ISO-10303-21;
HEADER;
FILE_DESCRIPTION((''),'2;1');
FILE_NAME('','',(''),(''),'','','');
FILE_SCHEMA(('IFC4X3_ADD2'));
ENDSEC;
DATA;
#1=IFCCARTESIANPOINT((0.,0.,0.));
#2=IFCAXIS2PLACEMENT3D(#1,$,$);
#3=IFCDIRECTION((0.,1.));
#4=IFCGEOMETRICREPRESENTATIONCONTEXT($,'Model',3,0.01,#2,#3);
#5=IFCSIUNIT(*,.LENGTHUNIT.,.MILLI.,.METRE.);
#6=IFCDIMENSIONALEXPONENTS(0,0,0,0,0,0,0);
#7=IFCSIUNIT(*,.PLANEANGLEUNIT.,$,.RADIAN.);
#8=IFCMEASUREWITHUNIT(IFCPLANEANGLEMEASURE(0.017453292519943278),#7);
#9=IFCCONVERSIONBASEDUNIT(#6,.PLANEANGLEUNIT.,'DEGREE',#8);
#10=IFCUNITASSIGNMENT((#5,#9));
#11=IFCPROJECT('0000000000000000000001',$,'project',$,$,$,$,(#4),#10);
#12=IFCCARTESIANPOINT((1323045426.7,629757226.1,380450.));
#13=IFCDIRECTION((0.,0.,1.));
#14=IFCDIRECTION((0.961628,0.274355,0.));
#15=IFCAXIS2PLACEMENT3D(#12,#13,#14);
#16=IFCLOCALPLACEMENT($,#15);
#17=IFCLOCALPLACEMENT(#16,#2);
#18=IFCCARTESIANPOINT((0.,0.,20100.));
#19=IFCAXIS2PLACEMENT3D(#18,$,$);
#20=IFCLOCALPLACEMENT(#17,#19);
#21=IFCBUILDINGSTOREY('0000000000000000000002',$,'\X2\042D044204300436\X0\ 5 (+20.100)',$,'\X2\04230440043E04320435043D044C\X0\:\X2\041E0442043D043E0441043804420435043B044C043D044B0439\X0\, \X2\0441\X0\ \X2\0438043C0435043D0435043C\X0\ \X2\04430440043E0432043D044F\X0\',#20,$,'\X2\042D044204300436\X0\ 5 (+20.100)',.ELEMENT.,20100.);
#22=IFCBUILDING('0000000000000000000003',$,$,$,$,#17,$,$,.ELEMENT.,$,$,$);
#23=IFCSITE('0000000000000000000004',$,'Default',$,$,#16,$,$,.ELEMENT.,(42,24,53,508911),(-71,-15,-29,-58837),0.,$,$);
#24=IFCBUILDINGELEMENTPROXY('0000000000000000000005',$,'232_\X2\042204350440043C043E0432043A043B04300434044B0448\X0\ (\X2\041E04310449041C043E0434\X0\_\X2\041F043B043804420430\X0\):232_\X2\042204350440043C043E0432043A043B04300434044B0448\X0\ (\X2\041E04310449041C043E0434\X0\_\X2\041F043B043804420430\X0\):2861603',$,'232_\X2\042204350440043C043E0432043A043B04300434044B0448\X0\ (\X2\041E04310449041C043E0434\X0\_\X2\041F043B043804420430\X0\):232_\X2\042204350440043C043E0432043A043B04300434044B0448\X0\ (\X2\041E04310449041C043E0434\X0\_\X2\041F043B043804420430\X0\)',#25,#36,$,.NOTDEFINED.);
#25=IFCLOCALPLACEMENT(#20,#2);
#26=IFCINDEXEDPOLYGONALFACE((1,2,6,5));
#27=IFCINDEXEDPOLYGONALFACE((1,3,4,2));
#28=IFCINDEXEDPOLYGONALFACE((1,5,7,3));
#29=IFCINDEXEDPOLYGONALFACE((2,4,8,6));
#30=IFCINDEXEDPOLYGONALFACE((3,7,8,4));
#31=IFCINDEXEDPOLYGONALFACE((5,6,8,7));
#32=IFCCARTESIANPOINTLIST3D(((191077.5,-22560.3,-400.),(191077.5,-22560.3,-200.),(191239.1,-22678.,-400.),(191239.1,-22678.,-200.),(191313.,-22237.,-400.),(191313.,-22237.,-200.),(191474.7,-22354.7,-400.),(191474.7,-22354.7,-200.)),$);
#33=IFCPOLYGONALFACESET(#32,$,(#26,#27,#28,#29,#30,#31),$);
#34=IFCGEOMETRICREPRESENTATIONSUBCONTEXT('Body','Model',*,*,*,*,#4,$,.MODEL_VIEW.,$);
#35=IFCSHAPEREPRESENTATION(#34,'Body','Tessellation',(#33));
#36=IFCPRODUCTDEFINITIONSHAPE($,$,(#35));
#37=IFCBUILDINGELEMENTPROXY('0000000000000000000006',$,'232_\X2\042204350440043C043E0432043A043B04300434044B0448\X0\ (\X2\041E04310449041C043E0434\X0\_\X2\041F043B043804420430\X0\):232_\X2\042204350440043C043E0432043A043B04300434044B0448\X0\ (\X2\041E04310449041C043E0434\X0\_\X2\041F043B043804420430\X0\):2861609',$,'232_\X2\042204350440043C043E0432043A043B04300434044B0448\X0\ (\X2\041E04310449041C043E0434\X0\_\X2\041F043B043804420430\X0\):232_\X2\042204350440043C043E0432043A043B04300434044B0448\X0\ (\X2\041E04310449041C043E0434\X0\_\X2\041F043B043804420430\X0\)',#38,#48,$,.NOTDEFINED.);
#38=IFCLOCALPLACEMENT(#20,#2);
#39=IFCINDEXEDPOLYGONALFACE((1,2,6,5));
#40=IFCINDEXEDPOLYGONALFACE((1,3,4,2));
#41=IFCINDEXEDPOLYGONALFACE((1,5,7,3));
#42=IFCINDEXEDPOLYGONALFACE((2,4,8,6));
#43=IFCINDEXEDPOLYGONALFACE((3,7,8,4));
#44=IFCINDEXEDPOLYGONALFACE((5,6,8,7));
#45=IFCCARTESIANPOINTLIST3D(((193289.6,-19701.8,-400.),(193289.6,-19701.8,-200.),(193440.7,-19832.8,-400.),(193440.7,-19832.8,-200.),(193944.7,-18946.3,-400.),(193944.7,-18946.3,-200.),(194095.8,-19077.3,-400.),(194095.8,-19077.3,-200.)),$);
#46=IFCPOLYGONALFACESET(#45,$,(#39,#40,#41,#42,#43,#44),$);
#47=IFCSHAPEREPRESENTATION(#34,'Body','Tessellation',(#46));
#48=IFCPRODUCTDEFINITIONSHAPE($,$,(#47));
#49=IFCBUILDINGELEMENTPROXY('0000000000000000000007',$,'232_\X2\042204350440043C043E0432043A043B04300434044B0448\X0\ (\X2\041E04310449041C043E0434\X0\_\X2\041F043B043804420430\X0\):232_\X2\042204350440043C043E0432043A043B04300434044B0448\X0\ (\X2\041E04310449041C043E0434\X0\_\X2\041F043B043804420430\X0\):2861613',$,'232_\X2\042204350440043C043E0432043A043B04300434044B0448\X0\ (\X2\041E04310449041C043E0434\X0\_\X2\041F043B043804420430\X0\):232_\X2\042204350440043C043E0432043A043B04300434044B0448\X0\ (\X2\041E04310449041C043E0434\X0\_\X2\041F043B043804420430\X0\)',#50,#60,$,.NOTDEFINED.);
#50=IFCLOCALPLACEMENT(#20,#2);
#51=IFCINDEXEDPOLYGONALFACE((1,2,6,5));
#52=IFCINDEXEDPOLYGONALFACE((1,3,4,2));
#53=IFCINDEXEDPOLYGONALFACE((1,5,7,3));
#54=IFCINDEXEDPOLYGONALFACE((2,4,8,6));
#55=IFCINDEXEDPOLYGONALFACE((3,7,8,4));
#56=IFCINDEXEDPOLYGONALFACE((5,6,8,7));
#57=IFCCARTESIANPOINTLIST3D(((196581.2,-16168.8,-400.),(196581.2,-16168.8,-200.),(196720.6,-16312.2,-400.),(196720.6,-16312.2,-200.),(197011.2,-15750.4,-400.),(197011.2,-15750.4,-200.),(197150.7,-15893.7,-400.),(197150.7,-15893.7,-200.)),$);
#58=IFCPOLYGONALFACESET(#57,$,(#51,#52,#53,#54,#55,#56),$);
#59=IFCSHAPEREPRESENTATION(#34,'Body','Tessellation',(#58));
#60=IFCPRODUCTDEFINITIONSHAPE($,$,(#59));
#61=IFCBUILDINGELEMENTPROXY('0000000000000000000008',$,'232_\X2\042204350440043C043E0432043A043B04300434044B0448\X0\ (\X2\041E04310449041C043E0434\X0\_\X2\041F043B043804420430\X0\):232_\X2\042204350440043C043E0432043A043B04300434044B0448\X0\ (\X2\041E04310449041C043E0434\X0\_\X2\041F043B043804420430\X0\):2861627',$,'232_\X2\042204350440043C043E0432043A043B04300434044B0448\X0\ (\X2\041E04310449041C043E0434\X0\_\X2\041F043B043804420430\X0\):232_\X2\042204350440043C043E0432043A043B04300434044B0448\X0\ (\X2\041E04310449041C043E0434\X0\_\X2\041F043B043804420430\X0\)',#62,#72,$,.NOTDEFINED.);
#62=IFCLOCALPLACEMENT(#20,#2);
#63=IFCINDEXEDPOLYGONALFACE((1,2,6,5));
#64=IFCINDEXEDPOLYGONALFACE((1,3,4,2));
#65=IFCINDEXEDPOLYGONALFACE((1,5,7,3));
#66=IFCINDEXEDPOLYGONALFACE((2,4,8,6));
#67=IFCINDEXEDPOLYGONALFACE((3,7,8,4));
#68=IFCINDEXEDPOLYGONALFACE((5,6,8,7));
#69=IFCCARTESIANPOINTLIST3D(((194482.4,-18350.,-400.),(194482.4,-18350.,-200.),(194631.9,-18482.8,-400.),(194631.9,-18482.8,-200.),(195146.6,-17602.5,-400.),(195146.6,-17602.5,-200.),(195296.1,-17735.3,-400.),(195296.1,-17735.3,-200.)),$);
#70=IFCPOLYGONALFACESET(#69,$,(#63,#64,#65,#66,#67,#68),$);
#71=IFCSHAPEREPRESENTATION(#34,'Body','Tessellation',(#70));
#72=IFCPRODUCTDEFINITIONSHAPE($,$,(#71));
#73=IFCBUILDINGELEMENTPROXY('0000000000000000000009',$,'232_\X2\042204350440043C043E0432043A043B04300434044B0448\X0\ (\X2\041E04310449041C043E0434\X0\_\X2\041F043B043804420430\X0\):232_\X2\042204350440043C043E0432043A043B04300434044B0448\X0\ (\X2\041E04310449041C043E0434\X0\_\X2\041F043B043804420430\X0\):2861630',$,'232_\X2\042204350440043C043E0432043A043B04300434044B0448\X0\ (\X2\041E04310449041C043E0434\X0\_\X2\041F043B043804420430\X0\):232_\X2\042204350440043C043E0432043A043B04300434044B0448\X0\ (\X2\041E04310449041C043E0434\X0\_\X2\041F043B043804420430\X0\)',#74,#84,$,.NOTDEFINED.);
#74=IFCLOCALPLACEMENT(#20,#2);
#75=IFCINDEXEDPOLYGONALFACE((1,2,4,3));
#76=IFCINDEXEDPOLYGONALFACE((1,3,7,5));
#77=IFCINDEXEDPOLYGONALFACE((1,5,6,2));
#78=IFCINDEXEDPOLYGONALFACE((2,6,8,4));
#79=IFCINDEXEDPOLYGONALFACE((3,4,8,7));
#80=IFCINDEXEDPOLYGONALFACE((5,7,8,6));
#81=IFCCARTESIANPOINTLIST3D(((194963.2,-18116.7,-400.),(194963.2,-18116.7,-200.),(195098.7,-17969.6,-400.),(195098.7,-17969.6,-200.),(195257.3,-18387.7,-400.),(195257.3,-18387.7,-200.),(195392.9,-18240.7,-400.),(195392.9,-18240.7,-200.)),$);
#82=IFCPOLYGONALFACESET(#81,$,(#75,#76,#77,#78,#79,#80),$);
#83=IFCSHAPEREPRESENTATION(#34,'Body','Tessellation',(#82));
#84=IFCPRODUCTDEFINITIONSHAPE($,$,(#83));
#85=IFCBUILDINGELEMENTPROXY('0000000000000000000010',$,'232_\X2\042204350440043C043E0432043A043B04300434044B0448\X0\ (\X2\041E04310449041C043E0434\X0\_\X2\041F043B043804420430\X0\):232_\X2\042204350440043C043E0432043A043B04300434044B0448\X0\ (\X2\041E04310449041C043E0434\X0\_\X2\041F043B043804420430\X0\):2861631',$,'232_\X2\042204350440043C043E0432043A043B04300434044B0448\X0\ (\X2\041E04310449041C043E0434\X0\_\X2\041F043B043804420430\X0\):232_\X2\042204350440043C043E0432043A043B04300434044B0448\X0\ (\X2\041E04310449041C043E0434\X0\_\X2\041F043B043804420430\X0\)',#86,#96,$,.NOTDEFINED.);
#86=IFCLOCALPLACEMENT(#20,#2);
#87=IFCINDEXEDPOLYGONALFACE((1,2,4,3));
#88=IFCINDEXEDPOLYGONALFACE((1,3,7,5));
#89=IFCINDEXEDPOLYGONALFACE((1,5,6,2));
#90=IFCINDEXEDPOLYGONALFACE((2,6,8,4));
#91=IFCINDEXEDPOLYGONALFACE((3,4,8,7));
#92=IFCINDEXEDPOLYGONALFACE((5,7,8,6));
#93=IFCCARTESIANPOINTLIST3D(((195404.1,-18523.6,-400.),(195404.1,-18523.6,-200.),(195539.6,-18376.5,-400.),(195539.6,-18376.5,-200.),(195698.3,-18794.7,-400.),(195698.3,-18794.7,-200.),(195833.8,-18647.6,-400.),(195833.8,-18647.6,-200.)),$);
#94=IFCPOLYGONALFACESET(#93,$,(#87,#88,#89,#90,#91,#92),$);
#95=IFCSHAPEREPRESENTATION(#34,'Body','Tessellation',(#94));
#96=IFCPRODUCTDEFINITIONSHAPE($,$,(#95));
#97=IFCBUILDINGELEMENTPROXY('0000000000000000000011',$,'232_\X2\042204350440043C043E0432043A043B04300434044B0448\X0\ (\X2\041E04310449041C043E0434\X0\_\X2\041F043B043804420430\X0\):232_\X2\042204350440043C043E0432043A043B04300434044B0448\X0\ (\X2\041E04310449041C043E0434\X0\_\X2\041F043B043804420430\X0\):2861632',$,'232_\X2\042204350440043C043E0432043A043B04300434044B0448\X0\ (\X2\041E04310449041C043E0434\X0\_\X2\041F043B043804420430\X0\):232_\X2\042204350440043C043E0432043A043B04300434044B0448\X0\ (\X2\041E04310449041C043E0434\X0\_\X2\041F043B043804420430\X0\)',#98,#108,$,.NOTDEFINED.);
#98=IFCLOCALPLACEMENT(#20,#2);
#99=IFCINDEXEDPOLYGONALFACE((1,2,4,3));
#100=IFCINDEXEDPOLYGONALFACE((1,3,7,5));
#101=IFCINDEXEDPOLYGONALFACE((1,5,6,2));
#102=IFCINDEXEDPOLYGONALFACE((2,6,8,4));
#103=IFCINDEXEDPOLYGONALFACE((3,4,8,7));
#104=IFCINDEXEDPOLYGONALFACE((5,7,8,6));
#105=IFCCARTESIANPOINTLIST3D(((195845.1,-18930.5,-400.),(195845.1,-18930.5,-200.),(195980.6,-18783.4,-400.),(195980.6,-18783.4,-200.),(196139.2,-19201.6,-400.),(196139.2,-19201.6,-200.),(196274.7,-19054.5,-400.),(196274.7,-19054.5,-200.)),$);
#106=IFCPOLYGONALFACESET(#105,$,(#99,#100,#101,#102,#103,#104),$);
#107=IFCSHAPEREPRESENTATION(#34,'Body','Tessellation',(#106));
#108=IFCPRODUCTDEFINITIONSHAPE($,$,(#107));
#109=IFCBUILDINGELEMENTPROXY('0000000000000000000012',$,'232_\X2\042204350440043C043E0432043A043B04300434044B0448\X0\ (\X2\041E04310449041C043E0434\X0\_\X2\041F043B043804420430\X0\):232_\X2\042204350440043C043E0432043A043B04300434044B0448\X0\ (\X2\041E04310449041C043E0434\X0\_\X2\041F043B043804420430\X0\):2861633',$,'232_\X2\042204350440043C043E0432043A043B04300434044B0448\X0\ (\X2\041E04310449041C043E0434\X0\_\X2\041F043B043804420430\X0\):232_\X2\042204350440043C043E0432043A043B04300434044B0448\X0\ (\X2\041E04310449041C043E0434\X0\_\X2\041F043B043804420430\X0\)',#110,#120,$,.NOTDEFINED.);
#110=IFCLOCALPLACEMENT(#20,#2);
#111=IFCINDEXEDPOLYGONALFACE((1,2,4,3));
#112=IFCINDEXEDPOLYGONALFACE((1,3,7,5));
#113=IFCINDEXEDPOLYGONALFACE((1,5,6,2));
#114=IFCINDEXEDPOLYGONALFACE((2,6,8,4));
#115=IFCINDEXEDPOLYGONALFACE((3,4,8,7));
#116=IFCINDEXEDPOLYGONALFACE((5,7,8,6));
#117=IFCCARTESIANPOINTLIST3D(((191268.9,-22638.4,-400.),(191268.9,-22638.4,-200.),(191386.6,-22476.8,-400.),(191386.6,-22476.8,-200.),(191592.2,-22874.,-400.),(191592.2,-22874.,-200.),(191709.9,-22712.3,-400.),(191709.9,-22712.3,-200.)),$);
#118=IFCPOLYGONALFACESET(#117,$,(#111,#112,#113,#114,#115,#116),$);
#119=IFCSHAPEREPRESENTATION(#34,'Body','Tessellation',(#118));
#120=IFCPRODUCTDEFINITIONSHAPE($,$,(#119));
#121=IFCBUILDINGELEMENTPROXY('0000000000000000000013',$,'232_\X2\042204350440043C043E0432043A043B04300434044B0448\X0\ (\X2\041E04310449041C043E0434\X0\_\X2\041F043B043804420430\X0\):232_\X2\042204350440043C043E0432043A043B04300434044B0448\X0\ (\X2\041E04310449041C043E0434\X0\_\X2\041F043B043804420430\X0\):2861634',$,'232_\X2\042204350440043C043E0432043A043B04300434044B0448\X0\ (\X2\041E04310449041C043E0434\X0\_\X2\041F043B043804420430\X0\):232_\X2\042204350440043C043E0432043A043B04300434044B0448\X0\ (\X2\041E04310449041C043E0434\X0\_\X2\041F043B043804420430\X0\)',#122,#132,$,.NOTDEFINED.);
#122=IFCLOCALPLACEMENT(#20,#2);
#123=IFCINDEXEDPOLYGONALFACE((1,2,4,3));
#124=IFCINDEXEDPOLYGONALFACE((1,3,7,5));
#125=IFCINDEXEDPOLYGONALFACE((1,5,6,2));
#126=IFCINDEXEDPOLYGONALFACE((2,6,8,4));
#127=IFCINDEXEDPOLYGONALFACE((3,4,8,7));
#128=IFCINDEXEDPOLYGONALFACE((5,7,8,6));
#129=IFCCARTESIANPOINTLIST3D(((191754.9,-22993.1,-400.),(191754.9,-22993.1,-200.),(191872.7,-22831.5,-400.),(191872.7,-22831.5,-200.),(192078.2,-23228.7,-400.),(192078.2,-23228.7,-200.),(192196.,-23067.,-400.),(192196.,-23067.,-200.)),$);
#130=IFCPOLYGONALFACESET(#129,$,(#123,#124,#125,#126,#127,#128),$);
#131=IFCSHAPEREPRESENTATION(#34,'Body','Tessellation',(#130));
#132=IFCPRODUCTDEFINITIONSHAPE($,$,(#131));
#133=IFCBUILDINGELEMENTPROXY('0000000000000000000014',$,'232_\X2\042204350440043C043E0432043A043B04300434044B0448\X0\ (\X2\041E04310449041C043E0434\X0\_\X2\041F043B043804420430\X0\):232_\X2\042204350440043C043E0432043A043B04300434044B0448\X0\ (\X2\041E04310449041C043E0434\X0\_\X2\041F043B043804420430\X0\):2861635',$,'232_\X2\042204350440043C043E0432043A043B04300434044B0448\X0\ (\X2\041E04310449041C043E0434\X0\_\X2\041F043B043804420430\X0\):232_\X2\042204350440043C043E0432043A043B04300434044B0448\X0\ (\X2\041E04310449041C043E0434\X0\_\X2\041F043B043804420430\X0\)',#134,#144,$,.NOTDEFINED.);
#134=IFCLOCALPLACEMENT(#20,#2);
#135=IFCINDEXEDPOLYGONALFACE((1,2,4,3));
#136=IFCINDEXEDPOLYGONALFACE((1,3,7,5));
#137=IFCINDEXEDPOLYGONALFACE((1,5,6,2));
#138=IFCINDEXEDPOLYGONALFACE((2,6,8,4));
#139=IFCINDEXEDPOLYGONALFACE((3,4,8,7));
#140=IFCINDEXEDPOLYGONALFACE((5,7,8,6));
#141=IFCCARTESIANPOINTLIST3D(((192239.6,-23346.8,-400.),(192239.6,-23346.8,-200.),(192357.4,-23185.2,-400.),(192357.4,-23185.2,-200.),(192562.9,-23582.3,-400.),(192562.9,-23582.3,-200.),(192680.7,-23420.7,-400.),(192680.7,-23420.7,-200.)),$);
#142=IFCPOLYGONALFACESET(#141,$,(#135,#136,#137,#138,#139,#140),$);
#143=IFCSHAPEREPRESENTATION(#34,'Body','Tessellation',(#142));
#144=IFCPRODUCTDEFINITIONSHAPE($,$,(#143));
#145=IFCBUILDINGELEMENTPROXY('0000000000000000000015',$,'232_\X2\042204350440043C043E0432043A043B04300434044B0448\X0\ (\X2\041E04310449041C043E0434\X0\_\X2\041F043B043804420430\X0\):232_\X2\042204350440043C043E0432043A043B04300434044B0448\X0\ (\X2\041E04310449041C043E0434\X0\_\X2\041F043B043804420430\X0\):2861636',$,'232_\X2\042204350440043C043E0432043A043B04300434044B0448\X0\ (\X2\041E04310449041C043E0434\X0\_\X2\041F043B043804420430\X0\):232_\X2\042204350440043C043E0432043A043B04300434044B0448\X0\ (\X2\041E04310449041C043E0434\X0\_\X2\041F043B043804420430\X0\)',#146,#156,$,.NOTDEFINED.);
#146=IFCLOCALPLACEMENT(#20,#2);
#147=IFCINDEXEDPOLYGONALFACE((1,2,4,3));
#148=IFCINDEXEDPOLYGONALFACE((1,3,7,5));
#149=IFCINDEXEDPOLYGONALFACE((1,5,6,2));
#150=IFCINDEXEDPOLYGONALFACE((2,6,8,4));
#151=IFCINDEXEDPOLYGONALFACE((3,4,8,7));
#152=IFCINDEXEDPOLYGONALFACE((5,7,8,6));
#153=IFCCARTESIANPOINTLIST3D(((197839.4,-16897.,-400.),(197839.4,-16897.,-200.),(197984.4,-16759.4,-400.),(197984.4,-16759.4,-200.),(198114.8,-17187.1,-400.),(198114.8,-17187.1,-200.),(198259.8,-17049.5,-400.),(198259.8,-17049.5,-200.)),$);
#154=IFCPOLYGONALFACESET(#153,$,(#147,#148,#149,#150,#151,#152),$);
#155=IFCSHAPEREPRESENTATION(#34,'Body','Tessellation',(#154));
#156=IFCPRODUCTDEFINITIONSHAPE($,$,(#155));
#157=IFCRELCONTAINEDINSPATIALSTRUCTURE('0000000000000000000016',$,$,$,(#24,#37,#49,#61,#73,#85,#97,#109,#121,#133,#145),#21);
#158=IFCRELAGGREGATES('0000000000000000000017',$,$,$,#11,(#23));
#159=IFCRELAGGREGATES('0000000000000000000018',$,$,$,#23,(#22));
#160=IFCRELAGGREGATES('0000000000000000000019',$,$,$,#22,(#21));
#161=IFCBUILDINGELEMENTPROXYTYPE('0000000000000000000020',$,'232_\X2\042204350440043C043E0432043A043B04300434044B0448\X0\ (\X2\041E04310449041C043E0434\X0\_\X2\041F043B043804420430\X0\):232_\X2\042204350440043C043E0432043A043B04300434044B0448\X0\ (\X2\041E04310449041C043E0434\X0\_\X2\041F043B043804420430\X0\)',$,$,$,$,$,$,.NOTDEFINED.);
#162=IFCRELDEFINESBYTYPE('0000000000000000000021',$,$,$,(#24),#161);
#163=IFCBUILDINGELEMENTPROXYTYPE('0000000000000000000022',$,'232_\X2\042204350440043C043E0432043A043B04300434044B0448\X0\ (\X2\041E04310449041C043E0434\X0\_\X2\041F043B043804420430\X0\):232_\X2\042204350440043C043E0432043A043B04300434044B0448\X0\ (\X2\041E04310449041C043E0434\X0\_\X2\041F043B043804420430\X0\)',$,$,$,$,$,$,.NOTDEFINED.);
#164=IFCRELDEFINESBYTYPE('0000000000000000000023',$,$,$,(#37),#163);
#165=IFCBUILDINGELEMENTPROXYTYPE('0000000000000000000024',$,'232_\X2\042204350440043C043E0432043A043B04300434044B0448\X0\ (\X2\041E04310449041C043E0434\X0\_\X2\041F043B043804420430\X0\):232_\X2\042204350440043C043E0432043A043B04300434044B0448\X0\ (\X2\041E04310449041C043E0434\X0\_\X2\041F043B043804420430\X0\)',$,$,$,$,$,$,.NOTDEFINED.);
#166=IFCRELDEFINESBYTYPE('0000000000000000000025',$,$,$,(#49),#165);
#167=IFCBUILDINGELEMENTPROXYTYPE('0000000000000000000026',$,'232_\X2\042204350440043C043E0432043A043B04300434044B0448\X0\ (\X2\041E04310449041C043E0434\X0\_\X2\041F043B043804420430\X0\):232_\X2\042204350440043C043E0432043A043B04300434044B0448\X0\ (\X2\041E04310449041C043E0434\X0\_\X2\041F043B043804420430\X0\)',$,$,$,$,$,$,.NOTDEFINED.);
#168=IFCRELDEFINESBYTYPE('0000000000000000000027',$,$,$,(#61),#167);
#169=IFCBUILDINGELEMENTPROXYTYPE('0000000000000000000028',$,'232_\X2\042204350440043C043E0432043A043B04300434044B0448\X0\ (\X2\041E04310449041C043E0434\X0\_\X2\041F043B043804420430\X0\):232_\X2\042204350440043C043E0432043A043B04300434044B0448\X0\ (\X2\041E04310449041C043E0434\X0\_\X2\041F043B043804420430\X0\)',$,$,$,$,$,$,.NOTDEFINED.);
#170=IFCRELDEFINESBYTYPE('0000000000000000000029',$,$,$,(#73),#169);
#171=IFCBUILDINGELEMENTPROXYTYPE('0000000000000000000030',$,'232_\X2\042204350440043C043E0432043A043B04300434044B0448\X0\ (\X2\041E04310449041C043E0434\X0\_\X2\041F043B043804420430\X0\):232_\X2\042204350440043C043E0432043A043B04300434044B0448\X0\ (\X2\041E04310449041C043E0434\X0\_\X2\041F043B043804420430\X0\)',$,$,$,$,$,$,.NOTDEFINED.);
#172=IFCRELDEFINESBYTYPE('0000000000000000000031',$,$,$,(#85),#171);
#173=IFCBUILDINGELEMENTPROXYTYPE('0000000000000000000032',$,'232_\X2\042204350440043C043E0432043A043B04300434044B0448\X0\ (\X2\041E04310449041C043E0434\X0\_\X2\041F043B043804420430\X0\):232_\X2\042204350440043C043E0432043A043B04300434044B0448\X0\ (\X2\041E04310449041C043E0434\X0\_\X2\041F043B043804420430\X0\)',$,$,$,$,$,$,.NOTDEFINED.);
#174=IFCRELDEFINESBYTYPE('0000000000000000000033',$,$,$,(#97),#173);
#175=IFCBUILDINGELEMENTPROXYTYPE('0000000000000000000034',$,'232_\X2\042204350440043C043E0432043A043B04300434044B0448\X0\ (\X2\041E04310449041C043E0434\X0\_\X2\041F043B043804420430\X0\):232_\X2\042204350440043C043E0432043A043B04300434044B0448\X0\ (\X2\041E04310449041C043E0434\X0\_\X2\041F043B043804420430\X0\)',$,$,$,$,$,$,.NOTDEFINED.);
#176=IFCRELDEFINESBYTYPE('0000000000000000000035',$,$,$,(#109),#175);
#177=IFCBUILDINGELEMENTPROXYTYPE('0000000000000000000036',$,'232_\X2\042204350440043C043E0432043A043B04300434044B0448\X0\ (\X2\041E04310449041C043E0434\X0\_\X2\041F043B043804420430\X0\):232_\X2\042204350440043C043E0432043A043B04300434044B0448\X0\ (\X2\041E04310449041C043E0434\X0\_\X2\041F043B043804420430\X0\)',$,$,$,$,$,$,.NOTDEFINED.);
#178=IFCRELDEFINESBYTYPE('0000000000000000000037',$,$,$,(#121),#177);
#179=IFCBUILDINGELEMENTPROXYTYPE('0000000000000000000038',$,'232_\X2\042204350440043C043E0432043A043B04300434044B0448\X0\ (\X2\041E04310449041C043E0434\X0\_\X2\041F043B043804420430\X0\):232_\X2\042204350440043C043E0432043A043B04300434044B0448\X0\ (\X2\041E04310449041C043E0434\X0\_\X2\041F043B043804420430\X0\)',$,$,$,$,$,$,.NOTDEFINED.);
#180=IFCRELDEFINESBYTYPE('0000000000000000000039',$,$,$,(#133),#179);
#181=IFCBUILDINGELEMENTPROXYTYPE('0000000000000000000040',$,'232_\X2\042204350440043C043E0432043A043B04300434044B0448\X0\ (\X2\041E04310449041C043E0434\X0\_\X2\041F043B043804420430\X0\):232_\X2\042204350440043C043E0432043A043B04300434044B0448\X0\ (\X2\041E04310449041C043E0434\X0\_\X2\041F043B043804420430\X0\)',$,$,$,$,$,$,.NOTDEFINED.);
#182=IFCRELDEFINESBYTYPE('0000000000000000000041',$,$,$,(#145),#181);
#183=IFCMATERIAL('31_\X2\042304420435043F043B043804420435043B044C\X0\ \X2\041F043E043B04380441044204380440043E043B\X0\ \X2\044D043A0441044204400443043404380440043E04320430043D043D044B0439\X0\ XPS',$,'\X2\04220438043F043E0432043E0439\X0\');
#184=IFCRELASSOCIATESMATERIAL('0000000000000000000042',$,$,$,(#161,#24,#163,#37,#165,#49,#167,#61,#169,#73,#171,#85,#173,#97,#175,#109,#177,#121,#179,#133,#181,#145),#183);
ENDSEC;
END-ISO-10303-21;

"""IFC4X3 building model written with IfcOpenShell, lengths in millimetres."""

from ifc_helpers import new_model, entity, si_unit, converted_unit, direction, frame, frame_2d, origin, origin_2d_with_axis, place, context, subcontext, project, spatial, rectangle, extrude, source, transform, mapped, material, type_object, type_shapes, element, save


model = new_model("IFC4X3")

# Units and contexts
model_context = context("Model", 3, precision=0.01, world=origin(), true_north=direction((0.0, 1.0)))
body_context = subcontext(model_context, "Body", "Model", "MODEL_VIEW")
ifc_project = project(units=[si_unit("LENGTHUNIT", "METRE", prefix="MILLI"), converted_unit("PLANEANGLEUNIT", "DEGREE", entity("IfcPlaneAngleMeasure", 0.017453292519943278), si_unit("PLANEANGLEUNIT", "RADIAN"), dimensions=[0, 0, 0, 0, 0, 0, 0])], contexts=[model_context])

# Site, building, storey
site_placement = place(None, frame((1323045426.7, 629757226.1, 380450.0), z_axis=(0.0, 0.0, 1.0), x_axis=(0.961628, 0.274355, 0.0)))
site = spatial("IfcSite", under=ifc_project, at=site_placement, Name="Default", CompositionType="ELEMENT", RefLatitude=(42, 24, 53, 508911), RefLongitude=(-71, -15, -29, -58837), RefElevation=0.0)
building_placement = place(site_placement, origin())
building = spatial("IfcBuilding", under=site, at=building_placement, CompositionType="ELEMENT")
storey_placement = place(building_placement, frame((0.0, 0.0, 20100.0)))
storey = spatial("IfcBuildingStorey", under=building, at=storey_placement, Name="Этаж 5 (+20.100)", ObjectType="Уровень:Относительный, с именем уровня", LongName="Этаж 5 (+20.100)", CompositionType="ELEMENT", Elevation=20100.0)

# Building element proxies
ifc_material_1 = material(Name="31_Утеплитель Полистирол экструдированный XPS", Category="Типовой")
building_element_proxy_type_1 = type_object("IfcBuildingElementProxyType", Name="232_Термовкладыш (ОбщМод_Плита):232_Термовкладыш (ОбщМод_Плита)", PredefinedType="NOTDEFINED", material=ifc_material_1)
shared_shape_1 = source(origin(), body_context, "Body", "SweptSolid", [
    extrude(rectangle(XDim=400.0, YDim=200.0, at=origin_2d_with_axis()), frame((191276.1, -22457.5, -200.0), z_axis=(0.0, 0.0, 1.0), x_axis=(0.588844, 0.808247, 0.0)), (0.0, 0.0, 1.0), 200.0),
])
type_shapes(building_element_proxy_type_1, [shared_shape_1])
proxy_1_placement = place(storey_placement, frame((0.0, 0.0, -200.0)))
element("IfcBuildingElementProxy", 1, at=proxy_1_placement, inside=storey, type_object=building_element_proxy_type_1, material=ifc_material_1, Name="232_Термовкладыш (ОбщМод_Плита):232_Термовкладыш (ОбщМод_Плита):2861603", ObjectType="232_Термовкладыш (ОбщМод_Плита):232_Термовкладыш (ОбщМод_Плита)", PredefinedType="NOTDEFINED", context=body_context, shape_type="MappedRepresentation", body=[
    mapped(shared_shape_1, transform((0.0, 0.0, 0.0), scale=1.0)),
])
building_element_proxy_type_2 = type_object("IfcBuildingElementProxyType", Name="232_Термовкладыш (ОбщМод_Плита):232_Термовкладыш (ОбщМод_Плита)", PredefinedType="NOTDEFINED", material=ifc_material_1)
shared_shape_2 = source(origin(), body_context, "Body", "SweptSolid", [
    extrude(rectangle(XDim=1000.0, YDim=200.0, at=frame_2d((0.0, 0.0), x_axis=(1.0, 0.0))), frame((193692.7, -19389.5, -200.0), z_axis=(0.0, 0.0, 1.0), x_axis=(0.65516, 0.75549, 0.0)), (0.0, 0.0, 1.0), 200.0),
])
type_shapes(building_element_proxy_type_2, [shared_shape_2])
proxy_2_placement = place(storey_placement, frame((0.0, 0.0, -200.0)))
element("IfcBuildingElementProxy", 2, at=proxy_2_placement, inside=storey, type_object=building_element_proxy_type_2, material=ifc_material_1, Name="232_Термовкладыш (ОбщМод_Плита):232_Термовкладыш (ОбщМод_Плита):2861609", ObjectType="232_Термовкладыш (ОбщМод_Плита):232_Термовкладыш (ОбщМод_Плита)", PredefinedType="NOTDEFINED", context=body_context, shape_type="MappedRepresentation", body=[
    mapped(shared_shape_2, transform((0.0, 0.0, 0.0), scale=1.0)),
])
building_element_proxy_type_3 = type_object("IfcBuildingElementProxyType", Name="232_Термовкладыш (ОбщМод_Плита):232_Термовкладыш (ОбщМод_Плита)", PredefinedType="NOTDEFINED", material=ifc_material_1)
shared_shape_3 = source(origin(), body_context, "Body", "SweptSolid", [
    extrude(rectangle(XDim=600.0, YDim=200.0, at=frame_2d((0.0, 0.0), x_axis=(1.0, 0.0))), frame((196865.9, -16031.3, -200.0), z_axis=(0.0, 0.0, 1.0), x_axis=(0.716712, 0.697369, 0.0)), (0.0, 0.0, 1.0), 200.0),
])
type_shapes(building_element_proxy_type_3, [shared_shape_3])
proxy_3_placement = place(storey_placement, frame((0.0, 0.0, -200.0)))
element("IfcBuildingElementProxy", 3, at=proxy_3_placement, inside=storey, type_object=building_element_proxy_type_3, material=ifc_material_1, Name="232_Термовкладыш (ОбщМод_Плита):232_Термовкладыш (ОбщМод_Плита):2861613", ObjectType="232_Термовкладыш (ОбщМод_Плита):232_Термовкладыш (ОбщМод_Плита)", PredefinedType="NOTDEFINED", context=body_context, shape_type="MappedRepresentation", body=[
    mapped(shared_shape_3, transform((0.0, 0.0, 0.0), scale=1.0)),
])
building_element_proxy_type_4 = type_object("IfcBuildingElementProxyType", Name="232_Термовкладыш (ОбщМод_Плита):232_Термовкладыш (ОбщМод_Плита)", PredefinedType="NOTDEFINED", material=ifc_material_1)
shared_shape_4 = source(origin(), body_context, "Body", "SweptSolid", [
    extrude(rectangle(XDim=1000.0, YDim=200.0, at=frame_2d((0.0, 0.0), x_axis=(1.0, 0.0))), frame((194889.2, -18042.7, -200.0), z_axis=(0.0, 0.0, 1.0), x_axis=(0.66421, 0.747546, 0.0)), (0.0, 0.0, 1.0), 200.0),
])
type_shapes(building_element_proxy_type_4, [shared_shape_4])
proxy_4_placement = place(storey_placement, frame((0.0, 0.0, -200.0)))
element("IfcBuildingElementProxy", 4, at=proxy_4_placement, inside=storey, type_object=building_element_proxy_type_4, material=ifc_material_1, Name="232_Термовкладыш (ОбщМод_Плита):232_Термовкладыш (ОбщМод_Плита):2861627", ObjectType="232_Термовкладыш (ОбщМод_Плита):232_Термовкладыш (ОбщМод_Плита)", PredefinedType="NOTDEFINED", context=body_context, shape_type="MappedRepresentation", body=[
    mapped(shared_shape_4, transform((0.0, 0.0, 0.0), scale=1.0)),
])
building_element_proxy_type_5 = type_object("IfcBuildingElementProxyType", Name="232_Термовкладыш (ОбщМод_Плита):232_Термовкладыш (ОбщМод_Плита)", PredefinedType="NOTDEFINED", material=ifc_material_1)
shared_shape_5 = source(origin(), body_context, "Body", "SweptSolid", [
    extrude(rectangle(XDim=400.0, YDim=200.0, at=frame_2d((0.0, 0.0), x_axis=(1.0, 0.0))), frame((195178.0, -18178.7, -200.0), z_axis=(0.0, 0.0, 1.0), x_axis=(0.735409, -0.677624, 0.0)), (0.0, 0.0, 1.0), 200.0),
])
type_shapes(building_element_proxy_type_5, [shared_shape_5])
proxy_5_placement = place(storey_placement, frame((0.0, 0.0, -200.0)))
element("IfcBuildingElementProxy", 5, at=proxy_5_placement, inside=storey, type_object=building_element_proxy_type_5, material=ifc_material_1, Name="232_Термовкладыш (ОбщМод_Плита):232_Термовкладыш (ОбщМод_Плита):2861630", ObjectType="232_Термовкладыш (ОбщМод_Плита):232_Термовкладыш (ОбщМод_Плита)", PredefinedType="NOTDEFINED", context=body_context, shape_type="MappedRepresentation", body=[
    mapped(shared_shape_5, transform((0.0, 0.0, 0.0), scale=1.0)),
])
building_element_proxy_type_6 = type_object("IfcBuildingElementProxyType", Name="232_Термовкладыш (ОбщМод_Плита):232_Термовкладыш (ОбщМод_Плита)", PredefinedType="NOTDEFINED", material=ifc_material_1)
shared_shape_6 = source(origin(), body_context, "Body", "SweptSolid", [
    extrude(rectangle(XDim=400.0, YDim=200.0, at=frame_2d((0.0, 0.0), x_axis=(1.0, 0.0))), frame((195619.0, -18585.6, -200.0), z_axis=(0.0, 0.0, 1.0), x_axis=(0.735409, -0.677624, 0.0)), (0.0, 0.0, 1.0), 200.0),
])
type_shapes(building_element_proxy_type_6, [shared_shape_6])
proxy_6_placement = place(storey_placement, frame((0.0, 0.0, -200.0)))
element("IfcBuildingElementProxy", 6, at=proxy_6_placement, inside=storey, type_object=building_element_proxy_type_6, material=ifc_material_1, Name="232_Термовкладыш (ОбщМод_Плита):232_Термовкладыш (ОбщМод_Плита):2861631", ObjectType="232_Термовкладыш (ОбщМод_Плита):232_Термовкладыш (ОбщМод_Плита)", PredefinedType="NOTDEFINED", context=body_context, shape_type="MappedRepresentation", body=[
    mapped(shared_shape_6, transform((0.0, 0.0, 0.0), scale=1.0)),
])
building_element_proxy_type_7 = type_object("IfcBuildingElementProxyType", Name="232_Термовкладыш (ОбщМод_Плита):232_Термовкладыш (ОбщМод_Плита)", PredefinedType="NOTDEFINED", material=ifc_material_1)
shared_shape_7 = source(origin(), body_context, "Body", "SweptSolid", [
    extrude(rectangle(XDim=400.0, YDim=200.0, at=frame_2d((0.0, 0.0), x_axis=(1.0, 0.0))), frame((196059.9, -18992.5, -200.0), z_axis=(0.0, 0.0, 1.0), x_axis=(0.735409, -0.677624, 0.0)), (0.0, 0.0, 1.0), 200.0),
])
type_shapes(building_element_proxy_type_7, [shared_shape_7])
proxy_7_placement = place(storey_placement, frame((0.0, 0.0, -200.0)))
element("IfcBuildingElementProxy", 7, at=proxy_7_placement, inside=storey, type_object=building_element_proxy_type_7, material=ifc_material_1, Name="232_Термовкладыш (ОбщМод_Плита):232_Термовкладыш (ОбщМод_Плита):2861632", ObjectType="232_Термовкладыш (ОбщМод_Плита):232_Термовкладыш (ОбщМод_Плита)", PredefinedType="NOTDEFINED", context=body_context, shape_type="MappedRepresentation", body=[
    mapped(shared_shape_7, transform((0.0, 0.0, 0.0), scale=1.0)),
])
building_element_proxy_type_8 = type_object("IfcBuildingElementProxyType", Name="232_Термовкладыш (ОбщМод_Плита):232_Термовкладыш (ОбщМод_Плита)", PredefinedType="NOTDEFINED", material=ifc_material_1)
shared_shape_8 = source(origin(), body_context, "Body", "SweptSolid", [
    extrude(rectangle(XDim=400.0, YDim=200.0, at=origin_2d_with_axis()), frame((191489.4, -22675.4, -200.0), z_axis=(0.0, 0.0, 1.0), x_axis=(-0.808247, 0.588844, 0.0)), (0.0, 0.0, 1.0), 200.0),
])
type_shapes(building_element_proxy_type_8, [shared_shape_8])
proxy_8_placement = place(storey_placement, frame((0.0, 0.0, -200.0)))
element("IfcBuildingElementProxy", 8, at=proxy_8_placement, inside=storey, type_object=building_element_proxy_type_8, material=ifc_material_1, Name="232_Термовкладыш (ОбщМод_Плита):232_Термовкладыш (ОбщМод_Плита):2861633", ObjectType="232_Термовкладыш (ОбщМод_Плита):232_Термовкладыш (ОбщМод_Плита)", PredefinedType="NOTDEFINED", context=body_context, shape_type="MappedRepresentation", body=[
    mapped(shared_shape_8, transform((0.0, 0.0, 0.0), scale=1.0)),
])
building_element_proxy_type_9 = type_object("IfcBuildingElementProxyType", Name="232_Термовкладыш (ОбщМод_Плита):232_Термовкладыш (ОбщМод_Плита)", PredefinedType="NOTDEFINED", material=ifc_material_1)
shared_shape_9 = source(origin(), body_context, "Body", "SweptSolid", [
    extrude(rectangle(XDim=400.0, YDim=200.0, at=frame_2d((0.0, 0.0), x_axis=(1.0, 0.0))), frame((191975.5, -23030.1, -200.0), z_axis=(0.0, 0.0, 1.0), x_axis=(-0.808247, 0.588844, 0.0)), (0.0, 0.0, 1.0), 200.0),
])
type_shapes(building_element_proxy_type_9, [shared_shape_9])
proxy_9_placement = place(storey_placement, frame((0.0, 0.0, -200.0)))
element("IfcBuildingElementProxy", 9, at=proxy_9_placement, inside=storey, type_object=building_element_proxy_type_9, material=ifc_material_1, Name="232_Термовкладыш (ОбщМод_Плита):232_Термовкладыш (ОбщМод_Плита):2861634", ObjectType="232_Термовкладыш (ОбщМод_Плита):232_Термовкладыш (ОбщМод_Плита)", PredefinedType="NOTDEFINED", context=body_context, shape_type="MappedRepresentation", body=[
    mapped(shared_shape_9, transform((0.0, 0.0, 0.0), scale=1.0)),
])
building_element_proxy_type_10 = type_object("IfcBuildingElementProxyType", Name="232_Термовкладыш (ОбщМод_Плита):232_Термовкладыш (ОбщМод_Плита)", PredefinedType="NOTDEFINED", material=ifc_material_1)
shared_shape_10 = source(origin(), body_context, "Body", "SweptSolid", [
    extrude(rectangle(XDim=400.0, YDim=200.0, at=frame_2d((0.0, 0.0), x_axis=(1.0, 0.0))), frame((192460.1, -23383.7, -200.0), z_axis=(0.0, 0.0, 1.0), x_axis=(-0.808247, 0.588844, 0.0)), (0.0, 0.0, 1.0), 200.0),
])
type_shapes(building_element_proxy_type_10, [shared_shape_10])
proxy_10_placement = place(storey_placement, frame((0.0, 0.0, -200.0)))
element("IfcBuildingElementProxy", 10, at=proxy_10_placement, inside=storey, type_object=building_element_proxy_type_10, material=ifc_material_1, Name="232_Термовкладыш (ОбщМод_Плита):232_Термовкладыш (ОбщМод_Плита):2861635", ObjectType="232_Термовкладыш (ОбщМод_Плита):232_Термовкладыш (ОбщМод_Плита)", PredefinedType="NOTDEFINED", context=body_context, shape_type="MappedRepresentation", body=[
    mapped(shared_shape_10, transform((0.0, 0.0, 0.0), scale=1.0)),
])
building_element_proxy_type_11 = type_object("IfcBuildingElementProxyType", Name="232_Термовкладыш (ОбщМод_Плита):232_Термовкладыш (ОбщМод_Плита)", PredefinedType="NOTDEFINED", material=ifc_material_1)
shared_shape_11 = source(origin(), body_context, "Body", "SweptSolid", [
    extrude(rectangle(XDim=400.0, YDim=200.0, at=frame_2d((0.0, 0.0), x_axis=(1.0, 0.0))), frame((198049.6, -16973.3, -200.0), z_axis=(0.0, 0.0, 1.0), x_axis=(-0.688483, 0.725252, 0.0)), (0.0, 0.0, 1.0), 200.0),
])
type_shapes(building_element_proxy_type_11, [shared_shape_11])
proxy_11_placement = place(storey_placement, frame((0.0, 0.0, -200.0)))
element("IfcBuildingElementProxy", 11, at=proxy_11_placement, inside=storey, type_object=building_element_proxy_type_11, material=ifc_material_1, Name="232_Термовкладыш (ОбщМод_Плита):232_Термовкладыш (ОбщМод_Плита):2861636", ObjectType="232_Термовкладыш (ОбщМод_Плита):232_Термовкладыш (ОбщМод_Плита)", PredefinedType="NOTDEFINED", context=body_context, shape_type="MappedRepresentation", body=[
    mapped(shared_shape_11, transform((0.0, 0.0, 0.0), scale=1.0)),
])

save(model, "model.ifc")
